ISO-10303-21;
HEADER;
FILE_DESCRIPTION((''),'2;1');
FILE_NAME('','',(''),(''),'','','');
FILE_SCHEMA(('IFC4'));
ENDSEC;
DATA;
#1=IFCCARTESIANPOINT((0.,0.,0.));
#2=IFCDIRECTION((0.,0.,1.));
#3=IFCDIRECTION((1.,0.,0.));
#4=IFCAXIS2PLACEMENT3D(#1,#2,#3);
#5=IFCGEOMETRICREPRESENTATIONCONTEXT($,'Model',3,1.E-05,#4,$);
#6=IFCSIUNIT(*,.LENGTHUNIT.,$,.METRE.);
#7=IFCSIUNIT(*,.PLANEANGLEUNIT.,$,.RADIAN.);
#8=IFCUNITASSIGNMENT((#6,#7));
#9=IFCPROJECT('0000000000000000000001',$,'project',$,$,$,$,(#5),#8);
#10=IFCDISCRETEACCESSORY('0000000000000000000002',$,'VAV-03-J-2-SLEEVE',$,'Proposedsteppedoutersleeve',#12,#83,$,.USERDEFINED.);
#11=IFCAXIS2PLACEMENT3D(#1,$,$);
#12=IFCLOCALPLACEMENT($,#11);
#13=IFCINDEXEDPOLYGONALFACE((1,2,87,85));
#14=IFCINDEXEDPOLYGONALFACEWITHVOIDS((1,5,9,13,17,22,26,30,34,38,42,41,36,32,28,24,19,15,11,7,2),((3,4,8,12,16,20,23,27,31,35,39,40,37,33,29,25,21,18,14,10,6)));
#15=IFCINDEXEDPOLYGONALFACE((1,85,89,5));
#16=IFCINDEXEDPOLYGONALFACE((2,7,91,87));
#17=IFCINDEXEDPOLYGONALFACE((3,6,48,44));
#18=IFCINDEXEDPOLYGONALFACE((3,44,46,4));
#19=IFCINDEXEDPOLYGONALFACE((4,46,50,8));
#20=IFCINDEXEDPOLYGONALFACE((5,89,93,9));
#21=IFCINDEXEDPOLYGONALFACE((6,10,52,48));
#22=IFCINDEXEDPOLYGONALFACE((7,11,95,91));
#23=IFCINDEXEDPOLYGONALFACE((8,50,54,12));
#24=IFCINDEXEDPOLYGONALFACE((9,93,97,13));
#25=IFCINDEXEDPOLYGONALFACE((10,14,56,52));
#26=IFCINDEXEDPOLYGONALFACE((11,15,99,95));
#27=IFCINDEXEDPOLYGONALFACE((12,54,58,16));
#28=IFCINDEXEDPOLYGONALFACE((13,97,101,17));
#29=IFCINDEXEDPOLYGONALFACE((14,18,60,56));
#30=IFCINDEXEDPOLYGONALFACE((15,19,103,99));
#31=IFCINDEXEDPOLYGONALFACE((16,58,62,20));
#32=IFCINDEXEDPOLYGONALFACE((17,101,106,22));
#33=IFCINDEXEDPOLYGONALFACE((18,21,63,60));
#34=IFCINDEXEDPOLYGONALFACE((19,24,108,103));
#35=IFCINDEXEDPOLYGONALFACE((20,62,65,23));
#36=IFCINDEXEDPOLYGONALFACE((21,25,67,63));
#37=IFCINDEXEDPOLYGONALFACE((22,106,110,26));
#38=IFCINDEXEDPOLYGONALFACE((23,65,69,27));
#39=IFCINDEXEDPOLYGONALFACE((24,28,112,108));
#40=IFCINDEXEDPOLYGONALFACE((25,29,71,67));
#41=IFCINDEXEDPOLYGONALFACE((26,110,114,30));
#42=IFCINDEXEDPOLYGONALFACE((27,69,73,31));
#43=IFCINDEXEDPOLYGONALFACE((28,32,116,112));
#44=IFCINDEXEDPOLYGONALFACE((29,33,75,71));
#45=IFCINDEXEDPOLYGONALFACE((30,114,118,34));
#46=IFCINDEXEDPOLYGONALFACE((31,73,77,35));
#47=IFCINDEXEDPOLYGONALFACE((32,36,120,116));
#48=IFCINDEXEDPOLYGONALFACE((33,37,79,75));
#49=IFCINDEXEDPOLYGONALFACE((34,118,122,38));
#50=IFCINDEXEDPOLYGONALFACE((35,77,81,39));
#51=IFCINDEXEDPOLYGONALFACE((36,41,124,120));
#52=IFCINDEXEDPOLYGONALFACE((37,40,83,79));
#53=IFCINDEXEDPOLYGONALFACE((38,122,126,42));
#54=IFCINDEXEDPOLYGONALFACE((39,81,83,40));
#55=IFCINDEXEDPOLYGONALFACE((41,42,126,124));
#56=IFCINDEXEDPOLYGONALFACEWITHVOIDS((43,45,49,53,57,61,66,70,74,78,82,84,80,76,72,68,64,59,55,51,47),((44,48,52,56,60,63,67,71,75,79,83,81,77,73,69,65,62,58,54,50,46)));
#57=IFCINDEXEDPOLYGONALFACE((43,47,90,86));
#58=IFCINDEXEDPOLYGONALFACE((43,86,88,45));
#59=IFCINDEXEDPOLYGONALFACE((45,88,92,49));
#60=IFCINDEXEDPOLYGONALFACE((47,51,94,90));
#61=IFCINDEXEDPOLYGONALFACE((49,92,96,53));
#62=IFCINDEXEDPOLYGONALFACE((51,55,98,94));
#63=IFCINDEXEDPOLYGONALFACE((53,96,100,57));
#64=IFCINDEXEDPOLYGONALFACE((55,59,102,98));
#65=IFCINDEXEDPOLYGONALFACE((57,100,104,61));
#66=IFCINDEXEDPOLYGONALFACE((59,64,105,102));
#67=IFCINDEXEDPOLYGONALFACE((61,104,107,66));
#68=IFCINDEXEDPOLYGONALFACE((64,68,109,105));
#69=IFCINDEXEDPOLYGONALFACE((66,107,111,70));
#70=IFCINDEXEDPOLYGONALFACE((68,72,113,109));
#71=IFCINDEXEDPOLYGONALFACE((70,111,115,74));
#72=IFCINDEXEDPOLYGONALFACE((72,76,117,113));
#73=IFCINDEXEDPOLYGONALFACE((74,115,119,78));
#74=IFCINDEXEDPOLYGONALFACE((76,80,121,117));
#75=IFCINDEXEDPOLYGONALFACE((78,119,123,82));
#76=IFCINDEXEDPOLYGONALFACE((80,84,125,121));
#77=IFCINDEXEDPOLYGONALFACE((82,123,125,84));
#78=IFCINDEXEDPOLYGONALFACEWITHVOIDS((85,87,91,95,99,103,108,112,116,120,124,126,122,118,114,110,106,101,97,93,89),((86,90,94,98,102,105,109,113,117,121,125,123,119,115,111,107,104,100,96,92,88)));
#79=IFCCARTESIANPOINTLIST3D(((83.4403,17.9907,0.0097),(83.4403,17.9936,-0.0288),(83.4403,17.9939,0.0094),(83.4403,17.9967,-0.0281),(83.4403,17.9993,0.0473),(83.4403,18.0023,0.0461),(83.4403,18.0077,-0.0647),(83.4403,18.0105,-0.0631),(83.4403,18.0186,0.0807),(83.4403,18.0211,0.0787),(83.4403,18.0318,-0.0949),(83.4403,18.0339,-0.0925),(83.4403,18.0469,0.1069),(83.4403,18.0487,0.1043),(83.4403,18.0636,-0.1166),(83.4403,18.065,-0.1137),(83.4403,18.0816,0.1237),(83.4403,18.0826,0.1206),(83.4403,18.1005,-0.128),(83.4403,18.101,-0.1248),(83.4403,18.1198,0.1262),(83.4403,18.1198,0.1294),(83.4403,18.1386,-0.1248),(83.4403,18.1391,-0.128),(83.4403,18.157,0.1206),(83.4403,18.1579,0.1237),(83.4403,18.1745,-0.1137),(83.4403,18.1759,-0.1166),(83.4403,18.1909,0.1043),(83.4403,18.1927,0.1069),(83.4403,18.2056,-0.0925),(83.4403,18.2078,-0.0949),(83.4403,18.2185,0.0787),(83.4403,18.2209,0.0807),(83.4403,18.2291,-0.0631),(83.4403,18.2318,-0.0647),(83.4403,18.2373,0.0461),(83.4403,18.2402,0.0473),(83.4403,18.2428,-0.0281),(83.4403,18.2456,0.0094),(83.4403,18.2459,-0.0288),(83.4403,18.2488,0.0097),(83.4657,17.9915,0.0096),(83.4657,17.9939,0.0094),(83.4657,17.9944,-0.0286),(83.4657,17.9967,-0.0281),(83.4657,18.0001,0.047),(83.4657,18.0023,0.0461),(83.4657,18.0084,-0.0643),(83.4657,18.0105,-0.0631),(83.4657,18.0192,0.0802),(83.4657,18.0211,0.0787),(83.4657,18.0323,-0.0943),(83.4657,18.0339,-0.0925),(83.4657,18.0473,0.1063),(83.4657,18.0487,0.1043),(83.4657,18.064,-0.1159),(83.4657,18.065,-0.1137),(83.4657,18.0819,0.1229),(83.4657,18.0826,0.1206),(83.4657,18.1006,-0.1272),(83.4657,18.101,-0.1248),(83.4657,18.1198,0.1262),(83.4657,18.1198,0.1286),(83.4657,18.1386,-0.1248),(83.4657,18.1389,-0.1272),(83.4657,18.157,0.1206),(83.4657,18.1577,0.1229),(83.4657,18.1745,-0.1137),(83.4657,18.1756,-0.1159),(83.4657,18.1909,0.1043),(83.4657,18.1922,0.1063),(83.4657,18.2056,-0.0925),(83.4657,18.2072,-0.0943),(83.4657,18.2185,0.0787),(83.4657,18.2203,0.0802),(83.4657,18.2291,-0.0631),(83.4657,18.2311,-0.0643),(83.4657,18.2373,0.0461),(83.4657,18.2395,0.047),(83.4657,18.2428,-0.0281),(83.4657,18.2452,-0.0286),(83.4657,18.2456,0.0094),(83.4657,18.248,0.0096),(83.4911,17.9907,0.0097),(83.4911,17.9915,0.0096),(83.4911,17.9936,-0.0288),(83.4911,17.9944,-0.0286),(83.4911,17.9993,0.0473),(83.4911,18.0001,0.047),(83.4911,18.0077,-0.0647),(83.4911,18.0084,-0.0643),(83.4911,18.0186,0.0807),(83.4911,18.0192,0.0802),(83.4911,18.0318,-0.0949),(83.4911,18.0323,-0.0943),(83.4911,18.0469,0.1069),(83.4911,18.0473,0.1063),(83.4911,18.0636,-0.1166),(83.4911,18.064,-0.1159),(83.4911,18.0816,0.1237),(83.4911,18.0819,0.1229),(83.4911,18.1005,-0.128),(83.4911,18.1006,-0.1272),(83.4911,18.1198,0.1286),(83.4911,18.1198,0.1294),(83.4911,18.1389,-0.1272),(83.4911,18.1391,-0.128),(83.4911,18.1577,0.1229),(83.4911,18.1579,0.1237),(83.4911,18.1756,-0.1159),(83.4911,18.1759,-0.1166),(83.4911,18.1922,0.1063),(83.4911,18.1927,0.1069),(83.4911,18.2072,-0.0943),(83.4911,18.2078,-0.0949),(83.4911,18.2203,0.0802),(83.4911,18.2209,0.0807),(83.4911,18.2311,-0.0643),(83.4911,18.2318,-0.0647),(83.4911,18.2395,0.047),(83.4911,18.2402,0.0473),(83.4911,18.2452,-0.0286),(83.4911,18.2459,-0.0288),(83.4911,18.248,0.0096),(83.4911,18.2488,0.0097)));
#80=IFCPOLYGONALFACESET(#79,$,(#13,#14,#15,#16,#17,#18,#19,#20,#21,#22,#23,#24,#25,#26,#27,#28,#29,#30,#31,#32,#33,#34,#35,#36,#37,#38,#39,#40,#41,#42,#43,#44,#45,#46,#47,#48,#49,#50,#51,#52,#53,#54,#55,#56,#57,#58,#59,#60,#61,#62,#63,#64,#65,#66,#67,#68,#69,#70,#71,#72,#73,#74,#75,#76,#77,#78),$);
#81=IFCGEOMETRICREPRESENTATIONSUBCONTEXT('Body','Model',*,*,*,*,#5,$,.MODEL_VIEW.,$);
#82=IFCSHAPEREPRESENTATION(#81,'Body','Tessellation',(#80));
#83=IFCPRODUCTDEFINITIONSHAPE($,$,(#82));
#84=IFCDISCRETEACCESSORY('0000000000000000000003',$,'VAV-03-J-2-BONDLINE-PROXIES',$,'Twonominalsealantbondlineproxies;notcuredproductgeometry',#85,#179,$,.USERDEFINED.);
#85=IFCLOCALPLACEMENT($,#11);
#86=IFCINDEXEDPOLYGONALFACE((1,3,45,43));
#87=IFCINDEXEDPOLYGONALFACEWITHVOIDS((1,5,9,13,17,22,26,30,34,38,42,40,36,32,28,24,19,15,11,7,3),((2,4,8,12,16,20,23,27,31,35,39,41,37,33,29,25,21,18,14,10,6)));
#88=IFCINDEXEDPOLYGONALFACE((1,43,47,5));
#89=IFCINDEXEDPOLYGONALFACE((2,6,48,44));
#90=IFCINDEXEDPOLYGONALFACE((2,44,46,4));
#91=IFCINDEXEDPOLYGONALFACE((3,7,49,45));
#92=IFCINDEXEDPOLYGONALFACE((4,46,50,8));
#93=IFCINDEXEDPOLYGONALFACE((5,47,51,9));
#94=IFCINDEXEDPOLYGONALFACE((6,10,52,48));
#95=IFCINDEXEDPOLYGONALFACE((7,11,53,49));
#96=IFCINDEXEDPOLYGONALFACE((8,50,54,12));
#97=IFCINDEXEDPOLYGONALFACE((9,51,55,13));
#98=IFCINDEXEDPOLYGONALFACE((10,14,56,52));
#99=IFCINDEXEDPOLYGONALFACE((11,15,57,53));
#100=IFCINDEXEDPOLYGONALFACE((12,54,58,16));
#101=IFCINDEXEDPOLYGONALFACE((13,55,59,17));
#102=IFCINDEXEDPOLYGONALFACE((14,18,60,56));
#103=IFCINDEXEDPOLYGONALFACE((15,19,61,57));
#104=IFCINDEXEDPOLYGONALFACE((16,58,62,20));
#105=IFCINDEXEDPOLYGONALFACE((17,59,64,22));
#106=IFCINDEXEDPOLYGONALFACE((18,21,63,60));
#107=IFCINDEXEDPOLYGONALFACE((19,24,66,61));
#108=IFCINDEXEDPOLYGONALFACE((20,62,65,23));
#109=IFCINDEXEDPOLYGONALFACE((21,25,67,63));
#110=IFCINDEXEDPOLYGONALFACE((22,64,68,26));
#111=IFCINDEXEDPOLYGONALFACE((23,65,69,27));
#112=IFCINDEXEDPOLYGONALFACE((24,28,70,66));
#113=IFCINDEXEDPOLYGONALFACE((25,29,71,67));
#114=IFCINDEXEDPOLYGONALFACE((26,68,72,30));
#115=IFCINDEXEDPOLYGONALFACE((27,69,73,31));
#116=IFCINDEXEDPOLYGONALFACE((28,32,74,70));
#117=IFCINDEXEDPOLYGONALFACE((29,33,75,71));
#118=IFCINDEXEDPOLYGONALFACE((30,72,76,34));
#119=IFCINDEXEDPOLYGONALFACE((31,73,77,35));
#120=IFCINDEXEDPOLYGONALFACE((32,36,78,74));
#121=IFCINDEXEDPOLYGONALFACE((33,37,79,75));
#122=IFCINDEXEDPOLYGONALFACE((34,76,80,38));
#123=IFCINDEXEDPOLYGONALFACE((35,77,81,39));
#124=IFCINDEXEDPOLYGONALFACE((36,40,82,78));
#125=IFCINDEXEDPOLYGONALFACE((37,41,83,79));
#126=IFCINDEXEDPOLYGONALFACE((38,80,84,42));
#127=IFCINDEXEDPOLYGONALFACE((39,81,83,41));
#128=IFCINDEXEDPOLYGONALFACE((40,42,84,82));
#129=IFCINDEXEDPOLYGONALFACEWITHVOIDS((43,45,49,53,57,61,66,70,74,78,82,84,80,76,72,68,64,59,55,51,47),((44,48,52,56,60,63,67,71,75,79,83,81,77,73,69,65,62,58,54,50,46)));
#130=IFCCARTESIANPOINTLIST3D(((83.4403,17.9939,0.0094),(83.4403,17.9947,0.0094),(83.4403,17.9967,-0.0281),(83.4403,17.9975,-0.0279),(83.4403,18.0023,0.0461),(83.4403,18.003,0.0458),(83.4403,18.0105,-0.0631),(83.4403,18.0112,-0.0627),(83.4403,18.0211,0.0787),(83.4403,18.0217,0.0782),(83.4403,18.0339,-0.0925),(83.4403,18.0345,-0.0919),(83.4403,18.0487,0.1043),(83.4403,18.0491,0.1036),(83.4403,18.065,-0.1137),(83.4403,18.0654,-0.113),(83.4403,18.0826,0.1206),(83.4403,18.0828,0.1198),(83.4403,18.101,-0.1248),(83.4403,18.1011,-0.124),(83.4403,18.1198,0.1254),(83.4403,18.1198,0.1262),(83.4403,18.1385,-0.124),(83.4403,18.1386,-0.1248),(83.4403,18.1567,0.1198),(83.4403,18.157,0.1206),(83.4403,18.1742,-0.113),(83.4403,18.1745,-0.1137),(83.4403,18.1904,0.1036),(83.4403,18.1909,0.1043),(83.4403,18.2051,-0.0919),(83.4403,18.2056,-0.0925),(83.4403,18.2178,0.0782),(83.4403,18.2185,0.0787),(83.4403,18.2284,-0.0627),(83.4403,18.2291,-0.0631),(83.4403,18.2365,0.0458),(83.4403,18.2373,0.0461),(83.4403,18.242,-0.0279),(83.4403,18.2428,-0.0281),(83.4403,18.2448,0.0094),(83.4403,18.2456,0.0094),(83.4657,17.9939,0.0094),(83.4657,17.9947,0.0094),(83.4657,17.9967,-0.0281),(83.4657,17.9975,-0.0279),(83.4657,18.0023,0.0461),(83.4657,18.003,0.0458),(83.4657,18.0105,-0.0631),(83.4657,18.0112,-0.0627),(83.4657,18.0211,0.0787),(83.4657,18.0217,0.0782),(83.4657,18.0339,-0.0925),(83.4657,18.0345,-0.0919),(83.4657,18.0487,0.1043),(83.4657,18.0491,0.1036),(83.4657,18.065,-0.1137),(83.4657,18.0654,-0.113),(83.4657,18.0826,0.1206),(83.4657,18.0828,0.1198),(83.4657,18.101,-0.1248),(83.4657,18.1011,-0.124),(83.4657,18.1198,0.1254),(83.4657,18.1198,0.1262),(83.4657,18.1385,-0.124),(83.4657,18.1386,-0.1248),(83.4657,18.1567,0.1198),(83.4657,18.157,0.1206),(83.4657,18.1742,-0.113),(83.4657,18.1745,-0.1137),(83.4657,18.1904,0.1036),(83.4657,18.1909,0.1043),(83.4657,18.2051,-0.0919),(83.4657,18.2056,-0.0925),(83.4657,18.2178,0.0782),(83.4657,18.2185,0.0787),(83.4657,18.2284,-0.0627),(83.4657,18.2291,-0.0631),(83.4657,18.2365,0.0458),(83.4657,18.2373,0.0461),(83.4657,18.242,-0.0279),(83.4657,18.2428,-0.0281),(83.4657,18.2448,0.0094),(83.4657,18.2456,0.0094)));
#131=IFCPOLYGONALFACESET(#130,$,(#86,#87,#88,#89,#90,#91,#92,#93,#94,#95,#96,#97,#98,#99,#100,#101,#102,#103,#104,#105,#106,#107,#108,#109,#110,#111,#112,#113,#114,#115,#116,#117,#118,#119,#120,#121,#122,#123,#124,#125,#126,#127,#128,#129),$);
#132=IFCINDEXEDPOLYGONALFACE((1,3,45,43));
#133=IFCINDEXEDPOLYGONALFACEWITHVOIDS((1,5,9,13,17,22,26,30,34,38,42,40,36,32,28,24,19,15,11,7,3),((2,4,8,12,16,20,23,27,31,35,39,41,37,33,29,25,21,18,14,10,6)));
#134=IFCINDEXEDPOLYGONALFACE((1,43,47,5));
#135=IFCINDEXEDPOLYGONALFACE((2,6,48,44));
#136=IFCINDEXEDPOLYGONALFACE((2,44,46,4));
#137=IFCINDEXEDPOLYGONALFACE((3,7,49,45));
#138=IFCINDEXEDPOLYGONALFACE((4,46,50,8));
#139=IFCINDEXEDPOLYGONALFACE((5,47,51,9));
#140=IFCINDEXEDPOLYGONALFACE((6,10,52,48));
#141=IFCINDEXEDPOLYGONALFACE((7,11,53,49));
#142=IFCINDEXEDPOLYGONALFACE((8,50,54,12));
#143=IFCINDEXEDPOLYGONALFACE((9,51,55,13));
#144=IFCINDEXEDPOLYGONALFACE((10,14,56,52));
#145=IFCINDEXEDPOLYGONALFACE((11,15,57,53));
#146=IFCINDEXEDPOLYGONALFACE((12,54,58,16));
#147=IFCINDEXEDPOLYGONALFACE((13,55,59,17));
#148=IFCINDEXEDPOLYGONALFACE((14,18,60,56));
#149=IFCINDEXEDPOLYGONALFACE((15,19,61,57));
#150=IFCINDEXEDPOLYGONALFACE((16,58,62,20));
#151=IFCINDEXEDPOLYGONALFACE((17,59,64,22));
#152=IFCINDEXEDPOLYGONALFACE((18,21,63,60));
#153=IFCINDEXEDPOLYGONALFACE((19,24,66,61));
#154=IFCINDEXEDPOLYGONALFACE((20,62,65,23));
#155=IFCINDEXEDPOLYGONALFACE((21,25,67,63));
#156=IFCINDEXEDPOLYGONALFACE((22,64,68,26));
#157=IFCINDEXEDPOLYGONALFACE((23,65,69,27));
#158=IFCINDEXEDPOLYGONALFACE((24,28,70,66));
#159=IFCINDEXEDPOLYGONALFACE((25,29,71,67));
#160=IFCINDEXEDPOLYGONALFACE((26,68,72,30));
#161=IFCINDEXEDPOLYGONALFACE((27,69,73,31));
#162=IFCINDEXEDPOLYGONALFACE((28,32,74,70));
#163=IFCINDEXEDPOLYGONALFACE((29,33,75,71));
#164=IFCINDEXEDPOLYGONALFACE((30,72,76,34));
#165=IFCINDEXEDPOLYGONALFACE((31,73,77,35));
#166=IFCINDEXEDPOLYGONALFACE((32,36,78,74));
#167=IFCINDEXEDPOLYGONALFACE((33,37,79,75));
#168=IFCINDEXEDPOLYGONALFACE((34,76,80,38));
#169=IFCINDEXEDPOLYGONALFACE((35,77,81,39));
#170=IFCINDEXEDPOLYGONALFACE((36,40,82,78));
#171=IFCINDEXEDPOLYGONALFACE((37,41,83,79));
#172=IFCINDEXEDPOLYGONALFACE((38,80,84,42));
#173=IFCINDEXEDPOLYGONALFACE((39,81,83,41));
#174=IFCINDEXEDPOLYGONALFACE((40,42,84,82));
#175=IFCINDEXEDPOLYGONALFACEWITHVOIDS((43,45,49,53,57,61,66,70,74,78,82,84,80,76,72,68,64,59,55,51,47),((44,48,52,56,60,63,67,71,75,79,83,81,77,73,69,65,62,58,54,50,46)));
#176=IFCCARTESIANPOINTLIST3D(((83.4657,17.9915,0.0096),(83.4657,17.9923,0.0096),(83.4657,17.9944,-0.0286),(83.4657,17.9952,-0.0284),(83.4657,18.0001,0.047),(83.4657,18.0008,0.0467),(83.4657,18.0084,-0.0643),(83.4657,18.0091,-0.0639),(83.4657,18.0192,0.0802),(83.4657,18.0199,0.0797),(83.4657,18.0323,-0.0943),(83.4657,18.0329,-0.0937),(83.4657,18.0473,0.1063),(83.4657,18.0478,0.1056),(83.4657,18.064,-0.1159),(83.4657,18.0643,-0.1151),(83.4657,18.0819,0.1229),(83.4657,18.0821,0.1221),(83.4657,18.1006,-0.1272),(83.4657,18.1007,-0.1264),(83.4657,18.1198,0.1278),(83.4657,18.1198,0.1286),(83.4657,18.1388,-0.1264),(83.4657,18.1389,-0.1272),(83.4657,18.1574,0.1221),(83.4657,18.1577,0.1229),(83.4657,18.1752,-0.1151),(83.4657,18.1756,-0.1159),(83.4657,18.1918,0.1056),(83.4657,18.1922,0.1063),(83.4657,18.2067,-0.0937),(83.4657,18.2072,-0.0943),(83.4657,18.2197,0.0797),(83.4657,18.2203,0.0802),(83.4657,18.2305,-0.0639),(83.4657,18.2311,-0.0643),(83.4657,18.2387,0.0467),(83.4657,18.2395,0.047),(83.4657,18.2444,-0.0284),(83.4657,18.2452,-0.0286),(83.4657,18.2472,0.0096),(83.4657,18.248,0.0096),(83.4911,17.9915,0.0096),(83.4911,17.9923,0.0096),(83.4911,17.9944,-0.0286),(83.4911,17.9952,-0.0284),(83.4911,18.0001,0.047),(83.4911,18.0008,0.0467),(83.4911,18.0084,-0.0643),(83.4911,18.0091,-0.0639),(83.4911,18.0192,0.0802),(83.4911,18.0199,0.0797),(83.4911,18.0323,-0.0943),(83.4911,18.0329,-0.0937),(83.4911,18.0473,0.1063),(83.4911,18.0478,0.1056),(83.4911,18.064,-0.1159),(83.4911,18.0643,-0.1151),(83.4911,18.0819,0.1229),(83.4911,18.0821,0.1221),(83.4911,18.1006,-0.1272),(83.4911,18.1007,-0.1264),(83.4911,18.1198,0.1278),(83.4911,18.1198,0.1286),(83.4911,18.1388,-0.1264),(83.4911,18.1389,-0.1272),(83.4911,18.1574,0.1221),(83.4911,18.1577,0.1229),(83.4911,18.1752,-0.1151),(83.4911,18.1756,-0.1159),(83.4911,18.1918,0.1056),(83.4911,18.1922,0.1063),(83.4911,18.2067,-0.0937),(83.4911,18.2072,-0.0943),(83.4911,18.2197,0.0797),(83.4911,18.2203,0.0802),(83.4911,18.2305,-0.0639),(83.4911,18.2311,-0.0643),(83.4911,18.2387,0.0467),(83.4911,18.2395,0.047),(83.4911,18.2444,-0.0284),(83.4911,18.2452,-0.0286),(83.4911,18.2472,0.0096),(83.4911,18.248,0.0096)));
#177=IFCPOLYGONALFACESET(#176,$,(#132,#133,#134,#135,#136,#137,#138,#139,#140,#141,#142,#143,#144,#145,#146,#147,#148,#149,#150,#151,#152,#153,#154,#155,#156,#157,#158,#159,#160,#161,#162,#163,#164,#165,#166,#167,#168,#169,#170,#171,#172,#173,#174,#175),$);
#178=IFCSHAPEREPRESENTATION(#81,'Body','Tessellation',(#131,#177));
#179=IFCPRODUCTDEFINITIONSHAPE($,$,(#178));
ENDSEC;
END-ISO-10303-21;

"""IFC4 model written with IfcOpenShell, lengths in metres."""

from ifc_helpers import new_model, entity, si_unit, frame, origin_with_axes, place, context, subcontext, project, element, save


model = new_model("IFC4")

# Units and contexts
model_context = context("Model", 3, precision=1e-05, world=origin_with_axes())
body_context = subcontext(model_context, "Body", "Model", "MODEL_VIEW")
ifc_project = project(units=[si_unit("LENGTHUNIT", "METRE"), si_unit("PLANEANGLEUNIT", "RADIAN")], contexts=[model_context])

# Discrete accessories
discrete_accessory_1_placement = place(None, frame((83.4657, 18.1198, 0.0), z_axis=(0.0, 1.0, 0.0), x_axis=(0.0, 0.0, 1.0)))
element("IfcDiscreteAccessory", 1, at=discrete_accessory_1_placement, Name="VAV-03-J-2-SLEEVE", ObjectType="Proposedsteppedoutersleeve", PredefinedType="USERDEFINED", context=body_context, shape_type="SweptSolid", body=[
    entity("IfcRevolvedAreaSolid", entity("IfcArbitraryClosedProfileDef", "AREA", None, entity("IfcPolyline", [entity("IfcCartesianPoint", [0.1262, -0.0254]), entity("IfcCartesianPoint", [0.1294, -0.0254]), entity("IfcCartesianPoint", [0.1294, 0.0254]), entity("IfcCartesianPoint", [0.1286, 0.0254]), entity("IfcCartesianPoint", [0.1286, 0.0]), entity("IfcCartesianPoint", [0.1262, 0.0]), entity("IfcCartesianPoint", [0.1262, -0.0254])])), entity("IfcAxis2Placement3D", entity("IfcCartesianPoint", [0.0, 0.0, 0.0])), entity("IfcAxis1Placement", entity("IfcCartesianPoint", [0.0, 0.0, 0.0]), entity("IfcDirection", [0.0, 1.0, 0.0])), 6.283185),
])
discrete_accessory_2_placement = place(None, frame((83.4657, 18.1198, 0.0), z_axis=(0.0, 1.0, 0.0), x_axis=(0.0, 0.0, 1.0)))
element("IfcDiscreteAccessory", 2, at=discrete_accessory_2_placement, Name="VAV-03-J-2-BONDLINE-PROXIES", ObjectType="Twonominalsealantbondlineproxies;notcuredproductgeometry", PredefinedType="USERDEFINED", context=body_context, shape_type="SweptSolid", body=[
    entity("IfcRevolvedAreaSolid", entity("IfcArbitraryClosedProfileDef", "AREA", None, entity("IfcPolyline", [entity("IfcCartesianPoint", [0.1254, -0.0254]), entity("IfcCartesianPoint", [0.1262, -0.0254]), entity("IfcCartesianPoint", [0.1262, 0.0]), entity("IfcCartesianPoint", [0.1254, 0.0]), entity("IfcCartesianPoint", [0.1254, -0.0254])])), entity("IfcAxis2Placement3D", entity("IfcCartesianPoint", [0.0, 0.0, 0.0])), entity("IfcAxis1Placement", entity("IfcCartesianPoint", [0.0, 0.0, 0.0]), entity("IfcDirection", [0.0, 1.0, 0.0])), 6.283185),
    entity("IfcRevolvedAreaSolid", entity("IfcArbitraryClosedProfileDef", "AREA", None, entity("IfcPolyline", [entity("IfcCartesianPoint", [0.1278, 0.0]), entity("IfcCartesianPoint", [0.1286, 0.0]), entity("IfcCartesianPoint", [0.1286, 0.0254]), entity("IfcCartesianPoint", [0.1278, 0.0254]), entity("IfcCartesianPoint", [0.1278, 0.0])])), entity("IfcAxis2Placement3D", entity("IfcCartesianPoint", [0.0, 0.0, 0.0])), entity("IfcAxis1Placement", entity("IfcCartesianPoint", [0.0, 0.0, 0.0]), entity("IfcDirection", [0.0, 1.0, 0.0])), 6.283185),
])

save(model, "model.ifc")
